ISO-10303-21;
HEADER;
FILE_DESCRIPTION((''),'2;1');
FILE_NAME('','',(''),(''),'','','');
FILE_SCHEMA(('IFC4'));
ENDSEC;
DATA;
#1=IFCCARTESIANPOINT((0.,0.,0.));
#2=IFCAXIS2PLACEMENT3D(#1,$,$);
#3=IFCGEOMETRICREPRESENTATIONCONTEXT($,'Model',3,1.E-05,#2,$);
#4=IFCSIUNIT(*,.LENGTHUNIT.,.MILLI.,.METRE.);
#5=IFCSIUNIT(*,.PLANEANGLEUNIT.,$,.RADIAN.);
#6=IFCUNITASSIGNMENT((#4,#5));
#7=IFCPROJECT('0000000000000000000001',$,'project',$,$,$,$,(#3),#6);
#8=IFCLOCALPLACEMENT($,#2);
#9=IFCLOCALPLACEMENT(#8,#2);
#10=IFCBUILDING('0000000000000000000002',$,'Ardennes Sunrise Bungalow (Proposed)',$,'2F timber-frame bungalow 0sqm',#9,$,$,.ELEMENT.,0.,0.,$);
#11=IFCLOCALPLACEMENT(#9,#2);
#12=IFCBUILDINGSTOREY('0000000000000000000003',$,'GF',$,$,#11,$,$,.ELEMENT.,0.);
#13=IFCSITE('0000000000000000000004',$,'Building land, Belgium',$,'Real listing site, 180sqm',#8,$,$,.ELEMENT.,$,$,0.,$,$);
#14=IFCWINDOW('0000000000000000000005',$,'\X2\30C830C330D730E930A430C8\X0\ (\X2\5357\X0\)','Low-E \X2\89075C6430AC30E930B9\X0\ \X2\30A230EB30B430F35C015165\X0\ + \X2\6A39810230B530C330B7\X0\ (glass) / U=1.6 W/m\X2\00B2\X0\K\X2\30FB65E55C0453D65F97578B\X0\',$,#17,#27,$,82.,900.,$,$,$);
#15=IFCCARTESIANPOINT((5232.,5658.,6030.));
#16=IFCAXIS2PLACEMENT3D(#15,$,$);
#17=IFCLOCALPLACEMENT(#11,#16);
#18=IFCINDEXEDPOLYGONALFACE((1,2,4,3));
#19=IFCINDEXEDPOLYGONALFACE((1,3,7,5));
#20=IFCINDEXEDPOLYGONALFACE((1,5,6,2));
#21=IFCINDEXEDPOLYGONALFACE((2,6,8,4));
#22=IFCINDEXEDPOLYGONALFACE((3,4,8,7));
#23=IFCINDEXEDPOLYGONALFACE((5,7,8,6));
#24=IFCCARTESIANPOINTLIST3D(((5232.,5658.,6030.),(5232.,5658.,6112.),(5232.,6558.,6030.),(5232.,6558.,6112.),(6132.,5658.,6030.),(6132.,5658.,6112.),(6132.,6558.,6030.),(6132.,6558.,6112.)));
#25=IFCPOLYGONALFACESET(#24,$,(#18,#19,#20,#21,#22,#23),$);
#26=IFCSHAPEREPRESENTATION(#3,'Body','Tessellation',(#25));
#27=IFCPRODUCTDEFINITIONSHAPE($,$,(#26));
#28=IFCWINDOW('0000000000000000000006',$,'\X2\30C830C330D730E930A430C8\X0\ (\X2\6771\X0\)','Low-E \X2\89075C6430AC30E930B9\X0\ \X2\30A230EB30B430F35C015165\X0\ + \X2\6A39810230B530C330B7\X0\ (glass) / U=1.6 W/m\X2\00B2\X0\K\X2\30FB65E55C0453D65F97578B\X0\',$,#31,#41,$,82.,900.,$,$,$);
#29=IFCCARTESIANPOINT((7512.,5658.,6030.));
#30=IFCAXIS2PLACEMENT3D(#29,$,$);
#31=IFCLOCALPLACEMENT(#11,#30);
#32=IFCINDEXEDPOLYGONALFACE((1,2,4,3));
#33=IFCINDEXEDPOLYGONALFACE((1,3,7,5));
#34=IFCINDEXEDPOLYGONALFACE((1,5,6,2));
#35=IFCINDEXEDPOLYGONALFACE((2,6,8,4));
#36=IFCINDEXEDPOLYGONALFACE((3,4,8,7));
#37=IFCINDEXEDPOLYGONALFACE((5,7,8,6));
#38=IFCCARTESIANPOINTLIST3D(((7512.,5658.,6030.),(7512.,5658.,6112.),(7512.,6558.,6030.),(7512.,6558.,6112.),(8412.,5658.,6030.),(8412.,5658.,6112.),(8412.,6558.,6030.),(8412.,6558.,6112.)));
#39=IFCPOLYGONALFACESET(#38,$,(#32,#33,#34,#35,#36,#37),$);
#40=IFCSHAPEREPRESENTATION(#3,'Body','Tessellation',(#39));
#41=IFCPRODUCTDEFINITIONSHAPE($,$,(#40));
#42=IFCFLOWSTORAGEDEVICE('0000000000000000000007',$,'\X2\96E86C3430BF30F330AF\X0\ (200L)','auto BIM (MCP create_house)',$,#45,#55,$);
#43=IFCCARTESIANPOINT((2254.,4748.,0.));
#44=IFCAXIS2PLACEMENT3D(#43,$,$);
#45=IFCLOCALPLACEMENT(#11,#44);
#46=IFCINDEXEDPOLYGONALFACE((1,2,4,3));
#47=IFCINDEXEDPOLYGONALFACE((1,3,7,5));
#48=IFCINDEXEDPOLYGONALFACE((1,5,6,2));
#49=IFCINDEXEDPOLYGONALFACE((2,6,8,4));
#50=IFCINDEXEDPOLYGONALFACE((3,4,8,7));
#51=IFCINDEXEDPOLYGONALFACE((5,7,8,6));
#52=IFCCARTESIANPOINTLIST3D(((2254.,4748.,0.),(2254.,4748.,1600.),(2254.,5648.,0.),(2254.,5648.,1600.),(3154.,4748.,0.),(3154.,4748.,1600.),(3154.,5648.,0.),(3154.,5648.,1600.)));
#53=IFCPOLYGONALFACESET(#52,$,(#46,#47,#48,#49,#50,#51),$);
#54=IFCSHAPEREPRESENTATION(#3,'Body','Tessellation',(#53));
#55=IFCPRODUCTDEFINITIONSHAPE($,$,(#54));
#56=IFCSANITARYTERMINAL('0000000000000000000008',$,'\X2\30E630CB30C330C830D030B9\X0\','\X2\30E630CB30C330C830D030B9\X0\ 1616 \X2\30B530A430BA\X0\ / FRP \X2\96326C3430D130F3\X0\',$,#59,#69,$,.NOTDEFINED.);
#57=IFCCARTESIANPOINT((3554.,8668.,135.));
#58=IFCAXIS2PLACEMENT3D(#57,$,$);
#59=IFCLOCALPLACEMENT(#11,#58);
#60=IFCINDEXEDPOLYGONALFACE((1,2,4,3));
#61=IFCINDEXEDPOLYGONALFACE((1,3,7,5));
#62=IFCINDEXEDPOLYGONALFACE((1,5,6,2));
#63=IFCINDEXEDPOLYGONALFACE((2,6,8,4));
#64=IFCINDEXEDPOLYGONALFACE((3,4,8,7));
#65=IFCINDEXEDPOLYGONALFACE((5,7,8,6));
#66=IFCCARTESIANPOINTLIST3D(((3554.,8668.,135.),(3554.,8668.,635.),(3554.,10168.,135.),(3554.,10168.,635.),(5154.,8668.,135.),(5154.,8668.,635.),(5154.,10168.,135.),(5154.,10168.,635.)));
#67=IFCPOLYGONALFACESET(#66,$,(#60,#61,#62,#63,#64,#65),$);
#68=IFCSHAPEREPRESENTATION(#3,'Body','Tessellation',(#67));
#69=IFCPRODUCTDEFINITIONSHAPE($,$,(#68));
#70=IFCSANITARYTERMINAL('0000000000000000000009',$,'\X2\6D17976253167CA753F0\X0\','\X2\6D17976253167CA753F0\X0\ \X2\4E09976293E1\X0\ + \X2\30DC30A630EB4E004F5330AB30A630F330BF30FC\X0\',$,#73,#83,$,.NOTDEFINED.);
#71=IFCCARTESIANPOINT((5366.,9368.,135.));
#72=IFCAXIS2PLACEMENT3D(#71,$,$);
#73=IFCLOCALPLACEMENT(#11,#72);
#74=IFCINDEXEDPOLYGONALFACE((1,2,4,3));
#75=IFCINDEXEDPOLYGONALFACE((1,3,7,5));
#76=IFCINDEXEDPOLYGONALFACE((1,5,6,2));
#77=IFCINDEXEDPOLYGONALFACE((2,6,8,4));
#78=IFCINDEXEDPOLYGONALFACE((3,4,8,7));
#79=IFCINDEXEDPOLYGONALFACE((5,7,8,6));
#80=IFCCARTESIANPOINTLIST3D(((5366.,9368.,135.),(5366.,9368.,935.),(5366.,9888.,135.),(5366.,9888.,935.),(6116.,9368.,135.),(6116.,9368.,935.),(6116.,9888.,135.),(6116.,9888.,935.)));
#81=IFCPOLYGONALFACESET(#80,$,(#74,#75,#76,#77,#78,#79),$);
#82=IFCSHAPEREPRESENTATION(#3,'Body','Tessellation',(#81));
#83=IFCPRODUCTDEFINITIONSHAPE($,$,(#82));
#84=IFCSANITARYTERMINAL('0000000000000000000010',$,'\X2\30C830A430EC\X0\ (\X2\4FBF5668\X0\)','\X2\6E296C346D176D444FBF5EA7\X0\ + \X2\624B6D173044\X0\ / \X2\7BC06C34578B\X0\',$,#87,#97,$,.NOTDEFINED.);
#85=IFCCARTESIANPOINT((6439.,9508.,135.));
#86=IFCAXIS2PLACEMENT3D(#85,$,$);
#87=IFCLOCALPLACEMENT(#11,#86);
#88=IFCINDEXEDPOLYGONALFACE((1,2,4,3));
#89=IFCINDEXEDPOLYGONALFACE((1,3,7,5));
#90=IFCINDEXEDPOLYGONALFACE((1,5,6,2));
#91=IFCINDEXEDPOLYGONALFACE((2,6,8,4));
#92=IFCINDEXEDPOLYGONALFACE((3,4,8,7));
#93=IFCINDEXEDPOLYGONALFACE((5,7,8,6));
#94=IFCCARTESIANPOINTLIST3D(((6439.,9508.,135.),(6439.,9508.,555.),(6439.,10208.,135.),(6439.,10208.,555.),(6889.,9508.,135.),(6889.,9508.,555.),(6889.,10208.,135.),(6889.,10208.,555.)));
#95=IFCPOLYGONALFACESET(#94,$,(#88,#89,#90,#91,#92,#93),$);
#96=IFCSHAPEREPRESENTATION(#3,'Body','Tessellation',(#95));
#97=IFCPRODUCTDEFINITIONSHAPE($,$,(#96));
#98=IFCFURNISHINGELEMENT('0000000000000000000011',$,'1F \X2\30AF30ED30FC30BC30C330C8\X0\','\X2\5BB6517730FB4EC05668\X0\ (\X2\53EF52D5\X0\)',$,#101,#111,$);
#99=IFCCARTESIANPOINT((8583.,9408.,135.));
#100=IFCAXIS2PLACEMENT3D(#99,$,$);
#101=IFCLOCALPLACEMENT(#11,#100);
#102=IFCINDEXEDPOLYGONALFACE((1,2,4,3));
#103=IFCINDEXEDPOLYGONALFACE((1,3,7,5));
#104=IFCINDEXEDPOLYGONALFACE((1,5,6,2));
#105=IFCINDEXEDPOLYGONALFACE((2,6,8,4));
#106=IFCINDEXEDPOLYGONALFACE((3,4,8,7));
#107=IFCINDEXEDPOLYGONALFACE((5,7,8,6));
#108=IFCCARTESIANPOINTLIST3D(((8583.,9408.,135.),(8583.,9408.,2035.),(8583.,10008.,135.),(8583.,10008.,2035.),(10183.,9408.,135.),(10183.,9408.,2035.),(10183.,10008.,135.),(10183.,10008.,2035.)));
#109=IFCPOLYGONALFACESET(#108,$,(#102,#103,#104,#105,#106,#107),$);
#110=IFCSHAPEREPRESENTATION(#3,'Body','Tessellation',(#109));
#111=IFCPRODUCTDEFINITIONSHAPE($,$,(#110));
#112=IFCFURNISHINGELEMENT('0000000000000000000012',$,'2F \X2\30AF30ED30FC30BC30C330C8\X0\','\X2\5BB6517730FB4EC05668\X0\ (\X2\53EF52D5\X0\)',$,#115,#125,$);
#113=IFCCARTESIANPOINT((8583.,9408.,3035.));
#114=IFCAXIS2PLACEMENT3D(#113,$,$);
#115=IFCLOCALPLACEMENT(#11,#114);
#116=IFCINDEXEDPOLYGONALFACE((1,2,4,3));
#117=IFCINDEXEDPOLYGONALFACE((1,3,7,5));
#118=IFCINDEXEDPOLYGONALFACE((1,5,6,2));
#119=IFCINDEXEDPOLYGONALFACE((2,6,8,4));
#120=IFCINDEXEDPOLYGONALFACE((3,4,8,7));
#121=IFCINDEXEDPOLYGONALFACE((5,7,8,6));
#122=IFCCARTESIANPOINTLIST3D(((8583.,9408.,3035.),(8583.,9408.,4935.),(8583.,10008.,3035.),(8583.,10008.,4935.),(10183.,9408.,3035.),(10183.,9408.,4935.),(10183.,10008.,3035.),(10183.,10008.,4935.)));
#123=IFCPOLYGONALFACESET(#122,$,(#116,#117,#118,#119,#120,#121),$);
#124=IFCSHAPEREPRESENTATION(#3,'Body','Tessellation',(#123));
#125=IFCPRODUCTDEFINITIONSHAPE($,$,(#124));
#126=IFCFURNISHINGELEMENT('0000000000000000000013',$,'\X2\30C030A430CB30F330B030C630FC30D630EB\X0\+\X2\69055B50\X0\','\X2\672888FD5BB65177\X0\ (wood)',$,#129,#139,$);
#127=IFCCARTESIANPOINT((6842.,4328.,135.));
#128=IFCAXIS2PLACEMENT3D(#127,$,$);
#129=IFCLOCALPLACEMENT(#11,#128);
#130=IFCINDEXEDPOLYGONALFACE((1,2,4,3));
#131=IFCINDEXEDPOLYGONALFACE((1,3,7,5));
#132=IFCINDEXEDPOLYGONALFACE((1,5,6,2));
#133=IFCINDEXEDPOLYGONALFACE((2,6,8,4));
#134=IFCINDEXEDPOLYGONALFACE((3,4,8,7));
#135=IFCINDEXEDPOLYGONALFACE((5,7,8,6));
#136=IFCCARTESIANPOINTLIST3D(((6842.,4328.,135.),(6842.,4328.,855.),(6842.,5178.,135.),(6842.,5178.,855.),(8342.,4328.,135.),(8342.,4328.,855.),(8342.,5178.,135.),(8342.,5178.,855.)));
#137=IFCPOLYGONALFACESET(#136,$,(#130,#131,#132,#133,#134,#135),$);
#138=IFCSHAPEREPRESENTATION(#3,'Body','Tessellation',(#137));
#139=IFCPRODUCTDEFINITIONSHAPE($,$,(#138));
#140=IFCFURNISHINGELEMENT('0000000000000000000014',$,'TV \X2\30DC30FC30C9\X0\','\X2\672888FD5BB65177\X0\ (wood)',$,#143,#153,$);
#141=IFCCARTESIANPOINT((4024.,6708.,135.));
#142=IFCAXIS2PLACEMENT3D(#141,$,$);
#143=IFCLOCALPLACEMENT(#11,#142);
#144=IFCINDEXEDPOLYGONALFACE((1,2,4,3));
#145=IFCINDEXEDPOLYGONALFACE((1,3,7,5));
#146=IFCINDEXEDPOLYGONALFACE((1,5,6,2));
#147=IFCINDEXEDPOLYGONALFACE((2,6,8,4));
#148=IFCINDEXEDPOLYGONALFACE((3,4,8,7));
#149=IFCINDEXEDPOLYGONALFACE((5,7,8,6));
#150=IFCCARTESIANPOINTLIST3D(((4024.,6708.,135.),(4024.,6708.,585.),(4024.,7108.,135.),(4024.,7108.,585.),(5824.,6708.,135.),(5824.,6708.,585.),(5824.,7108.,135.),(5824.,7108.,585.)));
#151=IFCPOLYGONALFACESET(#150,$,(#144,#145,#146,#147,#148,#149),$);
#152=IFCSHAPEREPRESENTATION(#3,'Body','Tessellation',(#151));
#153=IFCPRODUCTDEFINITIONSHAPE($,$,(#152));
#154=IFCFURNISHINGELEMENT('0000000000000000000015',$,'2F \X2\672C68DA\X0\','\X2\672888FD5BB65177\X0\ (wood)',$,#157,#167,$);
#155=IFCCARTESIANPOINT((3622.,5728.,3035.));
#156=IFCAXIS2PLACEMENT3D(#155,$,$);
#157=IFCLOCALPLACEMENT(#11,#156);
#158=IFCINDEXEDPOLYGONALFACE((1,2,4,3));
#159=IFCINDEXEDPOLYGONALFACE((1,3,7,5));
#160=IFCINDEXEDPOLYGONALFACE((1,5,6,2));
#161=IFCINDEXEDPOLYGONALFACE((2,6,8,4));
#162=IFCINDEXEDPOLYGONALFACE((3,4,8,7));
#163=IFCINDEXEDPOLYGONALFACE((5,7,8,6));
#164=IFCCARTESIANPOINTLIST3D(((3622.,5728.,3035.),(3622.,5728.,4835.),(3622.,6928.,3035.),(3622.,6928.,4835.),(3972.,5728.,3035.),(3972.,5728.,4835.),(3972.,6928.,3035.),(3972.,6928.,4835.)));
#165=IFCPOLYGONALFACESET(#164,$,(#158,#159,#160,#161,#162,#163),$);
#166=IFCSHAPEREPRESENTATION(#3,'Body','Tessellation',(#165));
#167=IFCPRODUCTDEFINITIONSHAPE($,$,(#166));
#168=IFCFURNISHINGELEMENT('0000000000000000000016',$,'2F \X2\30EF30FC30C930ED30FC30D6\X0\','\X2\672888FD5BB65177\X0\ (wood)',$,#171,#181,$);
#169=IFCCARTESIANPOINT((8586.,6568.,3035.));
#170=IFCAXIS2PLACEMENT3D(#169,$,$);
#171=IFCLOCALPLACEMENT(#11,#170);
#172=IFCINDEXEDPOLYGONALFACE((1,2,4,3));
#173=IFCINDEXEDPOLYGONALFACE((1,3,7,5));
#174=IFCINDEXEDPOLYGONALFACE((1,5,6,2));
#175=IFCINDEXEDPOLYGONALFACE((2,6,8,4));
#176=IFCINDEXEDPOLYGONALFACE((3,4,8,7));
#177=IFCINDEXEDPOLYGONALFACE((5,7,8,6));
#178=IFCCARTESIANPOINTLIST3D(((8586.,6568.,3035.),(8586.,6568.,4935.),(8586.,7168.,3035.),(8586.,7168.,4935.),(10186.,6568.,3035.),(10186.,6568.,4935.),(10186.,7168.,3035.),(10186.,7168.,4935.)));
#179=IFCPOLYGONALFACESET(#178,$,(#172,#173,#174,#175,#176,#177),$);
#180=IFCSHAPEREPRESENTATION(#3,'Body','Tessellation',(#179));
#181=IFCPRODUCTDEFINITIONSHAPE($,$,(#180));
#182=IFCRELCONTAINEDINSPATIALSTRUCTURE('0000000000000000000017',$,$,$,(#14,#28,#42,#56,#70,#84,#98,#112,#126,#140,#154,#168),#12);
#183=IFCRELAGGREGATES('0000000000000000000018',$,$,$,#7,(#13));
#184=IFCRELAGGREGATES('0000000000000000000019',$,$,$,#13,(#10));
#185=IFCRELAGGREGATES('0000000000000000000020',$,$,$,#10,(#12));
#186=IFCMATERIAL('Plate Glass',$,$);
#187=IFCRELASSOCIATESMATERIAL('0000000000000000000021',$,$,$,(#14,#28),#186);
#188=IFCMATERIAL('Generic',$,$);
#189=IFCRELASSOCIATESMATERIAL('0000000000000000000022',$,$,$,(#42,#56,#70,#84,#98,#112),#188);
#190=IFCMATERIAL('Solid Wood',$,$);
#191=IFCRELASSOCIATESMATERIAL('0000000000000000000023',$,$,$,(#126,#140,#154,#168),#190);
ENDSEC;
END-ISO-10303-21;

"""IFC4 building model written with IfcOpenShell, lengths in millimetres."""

from ifc_helpers import new_model, si_unit, frame, frame_2d, origin, place, context, project, spatial, rectangle, extrude, material, element, save


model = new_model("IFC4")

# Units and contexts
model_context = context("Model", 3, precision=1e-05, world=origin())
ifc_project = project(units=[si_unit("LENGTHUNIT", "METRE", prefix="MILLI"), si_unit("PLANEANGLEUNIT", "RADIAN")], contexts=[model_context])

# Site, building, storey
site_placement = place(None, origin())
site = spatial("IfcSite", under=ifc_project, at=site_placement, Name="Building land, Belgium", ObjectType="Real listing site, 180sqm", CompositionType="ELEMENT", RefElevation=0.0)
building_placement = place(site_placement, origin())
building = spatial("IfcBuilding", under=site, at=building_placement, Name="Ardennes Sunrise Bungalow (Proposed)", ObjectType="2F timber-frame bungalow 0sqm", CompositionType="ELEMENT", ElevationOfRefHeight=0.0, ElevationOfTerrain=0.0)
storey_placement = place(building_placement, origin())
storey = spatial("IfcBuildingStorey", under=building, at=storey_placement, Name="GF", CompositionType="ELEMENT", Elevation=0.0)

# Shared definitions
ifc_material_1 = material(Name="Solid Wood")
ifc_material_2 = material(Name="Plate Glass")

# Windows
window_1_placement = place(storey_placement, frame((5232.0, 5658.0, 6030.0)))
element("IfcWindow", 1, at=window_1_placement, inside=storey, material=ifc_material_2, Name="トップライト (南)", Description="Low-E 複層ガラス アルゴン封入 + 樹脂サッシ (glass) / U=1.6 W/m²K・日射取得型", OverallHeight=82.0, OverallWidth=900.0, context=model_context, shape_type="SweptSolid", body=[
    extrude(rectangle(XDim=900.0, YDim=900.0, at=frame_2d((450.0, 450.0))), frame((5232.0, 5658.0, 6030.0)), (0.0, 0.0, 1.0), 82.0),
])
window_2_placement = place(storey_placement, frame((7512.0, 5658.0, 6030.0)))
element("IfcWindow", 2, at=window_2_placement, inside=storey, material=ifc_material_2, Name="トップライト (東)", Description="Low-E 複層ガラス アルゴン封入 + 樹脂サッシ (glass) / U=1.6 W/m²K・日射取得型", OverallHeight=82.0, OverallWidth=900.0, context=model_context, shape_type="SweptSolid", body=[
    extrude(rectangle(XDim=900.0, YDim=900.0, at=frame_2d((450.0, 450.0))), frame((7512.0, 5658.0, 6030.0)), (0.0, 0.0, 1.0), 82.0),
])

# Flow storage device
ifc_material_3 = material(Name="Generic")
flow_storage_device_placement = place(storey_placement, frame((2254.0, 4748.0, 0.0)))
element("IfcFlowStorageDevice", 3, at=flow_storage_device_placement, inside=storey, material=ifc_material_3, Name="雨水タンク (200L)", Description="auto BIM (MCP create_house)", context=model_context, shape_type="SweptSolid", body=[
    extrude(rectangle(XDim=900.0, YDim=900.0, at=frame_2d((450.0, 450.0))), frame((2254.0, 4748.0, 0.0)), (0.0, 0.0, 1.0), 1600.0),
])

# Sanitary terminals
sanitary_terminal_1_placement = place(storey_placement, frame((3554.0, 8668.0, 135.0)))
element("IfcSanitaryTerminal", 4, at=sanitary_terminal_1_placement, inside=storey, material=ifc_material_3, Name="ユニットバス", Description="ユニットバス 1616 サイズ / FRP 防水パン", PredefinedType="NOTDEFINED", context=model_context, shape_type="SweptSolid", body=[
    extrude(rectangle(XDim=1600.0, YDim=1500.0, at=frame_2d((800.0, 750.0))), frame((3554.0, 8668.0, 135.0)), (0.0, 0.0, 1.0), 500.0),
])
sanitary_terminal_2_placement = place(storey_placement, frame((5366.0, 9368.0, 135.0)))
element("IfcSanitaryTerminal", 5, at=sanitary_terminal_2_placement, inside=storey, material=ifc_material_3, Name="洗面化粧台", Description="洗面化粧台 三面鏡 + ボウル一体カウンター", PredefinedType="NOTDEFINED", context=model_context, shape_type="SweptSolid", body=[
    extrude(rectangle(XDim=750.0, YDim=520.0, at=frame_2d((375.0, 260.0))), frame((5366.0, 9368.0, 135.0)), (0.0, 0.0, 1.0), 800.0),
])
sanitary_terminal_3_placement = place(storey_placement, frame((6439.0, 9508.0, 135.0)))
element("IfcSanitaryTerminal", 6, at=sanitary_terminal_3_placement, inside=storey, material=ifc_material_3, Name="トイレ (便器)", Description="温水洗浄便座 + 手洗い / 節水型", PredefinedType="NOTDEFINED", context=model_context, shape_type="SweptSolid", body=[
    extrude(rectangle(XDim=450.0, YDim=700.0, at=frame_2d((225.0, 350.0))), frame((6439.0, 9508.0, 135.0)), (0.0, 0.0, 1.0), 420.0),
])

# Furnishing elements
furnishing_1_placement = place(storey_placement, frame((8583.0, 9408.0, 135.0)))
element("IfcFurnishingElement", 7, at=furnishing_1_placement, inside=storey, material=ifc_material_3, Name="1F クローゼット", Description="家具・什器 (可動)", context=model_context, shape_type="SweptSolid", body=[
    extrude(rectangle(XDim=1600.0, YDim=600.0, at=frame_2d((800.0, 300.0))), frame((8583.0, 9408.0, 135.0)), (0.0, 0.0, 1.0), 1900.0),
])
furnishing_2_placement = place(storey_placement, frame((8583.0, 9408.0, 3035.0)))
element("IfcFurnishingElement", 8, at=furnishing_2_placement, inside=storey, material=ifc_material_3, Name="2F クローゼット", Description="家具・什器 (可動)", context=model_context, shape_type="SweptSolid", body=[
    extrude(rectangle(XDim=1600.0, YDim=600.0, at=frame_2d((800.0, 300.0))), frame((8583.0, 9408.0, 3035.0)), (0.0, 0.0, 1.0), 1900.0),
])
furnishing_3_placement = place(storey_placement, frame((6842.0, 4328.0, 135.0)))
element("IfcFurnishingElement", 9, at=furnishing_3_placement, inside=storey, material=ifc_material_1, Name="ダイニングテーブル+椅子", Description="木製家具 (wood)", context=model_context, shape_type="SweptSolid", body=[
    extrude(rectangle(XDim=1500.0, YDim=850.0, at=frame_2d((750.0, 425.0))), frame((6842.0, 4328.0, 135.0)), (0.0, 0.0, 1.0), 720.0),
])
furnishing_4_placement = place(storey_placement, frame((4024.0, 6708.0, 135.0)))
element("IfcFurnishingElement", 10, at=furnishing_4_placement, inside=storey, material=ifc_material_1, Name="TV ボード", Description="木製家具 (wood)", context=model_context, shape_type="SweptSolid", body=[
    extrude(rectangle(XDim=1800.0, YDim=400.0, at=frame_2d((900.0, 200.0))), frame((4024.0, 6708.0, 135.0)), (0.0, 0.0, 1.0), 450.0),
])
furnishing_5_placement = place(storey_placement, frame((3622.0, 5728.0, 3035.0)))
element("IfcFurnishingElement", 11, at=furnishing_5_placement, inside=storey, material=ifc_material_1, Name="2F 本棚", Description="木製家具 (wood)", context=model_context, shape_type="SweptSolid", body=[
    extrude(rectangle(XDim=350.0, YDim=1200.0, at=frame_2d((175.0, 600.0))), frame((3622.0, 5728.0, 3035.0)), (0.0, 0.0, 1.0), 1800.0),
])
furnishing_6_placement = place(storey_placement, frame((8586.0, 6568.0, 3035.0)))
element("IfcFurnishingElement", 12, at=furnishing_6_placement, inside=storey, material=ifc_material_1, Name="2F ワードローブ", Description="木製家具 (wood)", context=model_context, shape_type="SweptSolid", body=[
    extrude(rectangle(XDim=1600.0, YDim=600.0, at=frame_2d((800.0, 300.0))), frame((8586.0, 6568.0, 3035.0)), (0.0, 0.0, 1.0), 1900.0),
])

save(model, "model.ifc")
